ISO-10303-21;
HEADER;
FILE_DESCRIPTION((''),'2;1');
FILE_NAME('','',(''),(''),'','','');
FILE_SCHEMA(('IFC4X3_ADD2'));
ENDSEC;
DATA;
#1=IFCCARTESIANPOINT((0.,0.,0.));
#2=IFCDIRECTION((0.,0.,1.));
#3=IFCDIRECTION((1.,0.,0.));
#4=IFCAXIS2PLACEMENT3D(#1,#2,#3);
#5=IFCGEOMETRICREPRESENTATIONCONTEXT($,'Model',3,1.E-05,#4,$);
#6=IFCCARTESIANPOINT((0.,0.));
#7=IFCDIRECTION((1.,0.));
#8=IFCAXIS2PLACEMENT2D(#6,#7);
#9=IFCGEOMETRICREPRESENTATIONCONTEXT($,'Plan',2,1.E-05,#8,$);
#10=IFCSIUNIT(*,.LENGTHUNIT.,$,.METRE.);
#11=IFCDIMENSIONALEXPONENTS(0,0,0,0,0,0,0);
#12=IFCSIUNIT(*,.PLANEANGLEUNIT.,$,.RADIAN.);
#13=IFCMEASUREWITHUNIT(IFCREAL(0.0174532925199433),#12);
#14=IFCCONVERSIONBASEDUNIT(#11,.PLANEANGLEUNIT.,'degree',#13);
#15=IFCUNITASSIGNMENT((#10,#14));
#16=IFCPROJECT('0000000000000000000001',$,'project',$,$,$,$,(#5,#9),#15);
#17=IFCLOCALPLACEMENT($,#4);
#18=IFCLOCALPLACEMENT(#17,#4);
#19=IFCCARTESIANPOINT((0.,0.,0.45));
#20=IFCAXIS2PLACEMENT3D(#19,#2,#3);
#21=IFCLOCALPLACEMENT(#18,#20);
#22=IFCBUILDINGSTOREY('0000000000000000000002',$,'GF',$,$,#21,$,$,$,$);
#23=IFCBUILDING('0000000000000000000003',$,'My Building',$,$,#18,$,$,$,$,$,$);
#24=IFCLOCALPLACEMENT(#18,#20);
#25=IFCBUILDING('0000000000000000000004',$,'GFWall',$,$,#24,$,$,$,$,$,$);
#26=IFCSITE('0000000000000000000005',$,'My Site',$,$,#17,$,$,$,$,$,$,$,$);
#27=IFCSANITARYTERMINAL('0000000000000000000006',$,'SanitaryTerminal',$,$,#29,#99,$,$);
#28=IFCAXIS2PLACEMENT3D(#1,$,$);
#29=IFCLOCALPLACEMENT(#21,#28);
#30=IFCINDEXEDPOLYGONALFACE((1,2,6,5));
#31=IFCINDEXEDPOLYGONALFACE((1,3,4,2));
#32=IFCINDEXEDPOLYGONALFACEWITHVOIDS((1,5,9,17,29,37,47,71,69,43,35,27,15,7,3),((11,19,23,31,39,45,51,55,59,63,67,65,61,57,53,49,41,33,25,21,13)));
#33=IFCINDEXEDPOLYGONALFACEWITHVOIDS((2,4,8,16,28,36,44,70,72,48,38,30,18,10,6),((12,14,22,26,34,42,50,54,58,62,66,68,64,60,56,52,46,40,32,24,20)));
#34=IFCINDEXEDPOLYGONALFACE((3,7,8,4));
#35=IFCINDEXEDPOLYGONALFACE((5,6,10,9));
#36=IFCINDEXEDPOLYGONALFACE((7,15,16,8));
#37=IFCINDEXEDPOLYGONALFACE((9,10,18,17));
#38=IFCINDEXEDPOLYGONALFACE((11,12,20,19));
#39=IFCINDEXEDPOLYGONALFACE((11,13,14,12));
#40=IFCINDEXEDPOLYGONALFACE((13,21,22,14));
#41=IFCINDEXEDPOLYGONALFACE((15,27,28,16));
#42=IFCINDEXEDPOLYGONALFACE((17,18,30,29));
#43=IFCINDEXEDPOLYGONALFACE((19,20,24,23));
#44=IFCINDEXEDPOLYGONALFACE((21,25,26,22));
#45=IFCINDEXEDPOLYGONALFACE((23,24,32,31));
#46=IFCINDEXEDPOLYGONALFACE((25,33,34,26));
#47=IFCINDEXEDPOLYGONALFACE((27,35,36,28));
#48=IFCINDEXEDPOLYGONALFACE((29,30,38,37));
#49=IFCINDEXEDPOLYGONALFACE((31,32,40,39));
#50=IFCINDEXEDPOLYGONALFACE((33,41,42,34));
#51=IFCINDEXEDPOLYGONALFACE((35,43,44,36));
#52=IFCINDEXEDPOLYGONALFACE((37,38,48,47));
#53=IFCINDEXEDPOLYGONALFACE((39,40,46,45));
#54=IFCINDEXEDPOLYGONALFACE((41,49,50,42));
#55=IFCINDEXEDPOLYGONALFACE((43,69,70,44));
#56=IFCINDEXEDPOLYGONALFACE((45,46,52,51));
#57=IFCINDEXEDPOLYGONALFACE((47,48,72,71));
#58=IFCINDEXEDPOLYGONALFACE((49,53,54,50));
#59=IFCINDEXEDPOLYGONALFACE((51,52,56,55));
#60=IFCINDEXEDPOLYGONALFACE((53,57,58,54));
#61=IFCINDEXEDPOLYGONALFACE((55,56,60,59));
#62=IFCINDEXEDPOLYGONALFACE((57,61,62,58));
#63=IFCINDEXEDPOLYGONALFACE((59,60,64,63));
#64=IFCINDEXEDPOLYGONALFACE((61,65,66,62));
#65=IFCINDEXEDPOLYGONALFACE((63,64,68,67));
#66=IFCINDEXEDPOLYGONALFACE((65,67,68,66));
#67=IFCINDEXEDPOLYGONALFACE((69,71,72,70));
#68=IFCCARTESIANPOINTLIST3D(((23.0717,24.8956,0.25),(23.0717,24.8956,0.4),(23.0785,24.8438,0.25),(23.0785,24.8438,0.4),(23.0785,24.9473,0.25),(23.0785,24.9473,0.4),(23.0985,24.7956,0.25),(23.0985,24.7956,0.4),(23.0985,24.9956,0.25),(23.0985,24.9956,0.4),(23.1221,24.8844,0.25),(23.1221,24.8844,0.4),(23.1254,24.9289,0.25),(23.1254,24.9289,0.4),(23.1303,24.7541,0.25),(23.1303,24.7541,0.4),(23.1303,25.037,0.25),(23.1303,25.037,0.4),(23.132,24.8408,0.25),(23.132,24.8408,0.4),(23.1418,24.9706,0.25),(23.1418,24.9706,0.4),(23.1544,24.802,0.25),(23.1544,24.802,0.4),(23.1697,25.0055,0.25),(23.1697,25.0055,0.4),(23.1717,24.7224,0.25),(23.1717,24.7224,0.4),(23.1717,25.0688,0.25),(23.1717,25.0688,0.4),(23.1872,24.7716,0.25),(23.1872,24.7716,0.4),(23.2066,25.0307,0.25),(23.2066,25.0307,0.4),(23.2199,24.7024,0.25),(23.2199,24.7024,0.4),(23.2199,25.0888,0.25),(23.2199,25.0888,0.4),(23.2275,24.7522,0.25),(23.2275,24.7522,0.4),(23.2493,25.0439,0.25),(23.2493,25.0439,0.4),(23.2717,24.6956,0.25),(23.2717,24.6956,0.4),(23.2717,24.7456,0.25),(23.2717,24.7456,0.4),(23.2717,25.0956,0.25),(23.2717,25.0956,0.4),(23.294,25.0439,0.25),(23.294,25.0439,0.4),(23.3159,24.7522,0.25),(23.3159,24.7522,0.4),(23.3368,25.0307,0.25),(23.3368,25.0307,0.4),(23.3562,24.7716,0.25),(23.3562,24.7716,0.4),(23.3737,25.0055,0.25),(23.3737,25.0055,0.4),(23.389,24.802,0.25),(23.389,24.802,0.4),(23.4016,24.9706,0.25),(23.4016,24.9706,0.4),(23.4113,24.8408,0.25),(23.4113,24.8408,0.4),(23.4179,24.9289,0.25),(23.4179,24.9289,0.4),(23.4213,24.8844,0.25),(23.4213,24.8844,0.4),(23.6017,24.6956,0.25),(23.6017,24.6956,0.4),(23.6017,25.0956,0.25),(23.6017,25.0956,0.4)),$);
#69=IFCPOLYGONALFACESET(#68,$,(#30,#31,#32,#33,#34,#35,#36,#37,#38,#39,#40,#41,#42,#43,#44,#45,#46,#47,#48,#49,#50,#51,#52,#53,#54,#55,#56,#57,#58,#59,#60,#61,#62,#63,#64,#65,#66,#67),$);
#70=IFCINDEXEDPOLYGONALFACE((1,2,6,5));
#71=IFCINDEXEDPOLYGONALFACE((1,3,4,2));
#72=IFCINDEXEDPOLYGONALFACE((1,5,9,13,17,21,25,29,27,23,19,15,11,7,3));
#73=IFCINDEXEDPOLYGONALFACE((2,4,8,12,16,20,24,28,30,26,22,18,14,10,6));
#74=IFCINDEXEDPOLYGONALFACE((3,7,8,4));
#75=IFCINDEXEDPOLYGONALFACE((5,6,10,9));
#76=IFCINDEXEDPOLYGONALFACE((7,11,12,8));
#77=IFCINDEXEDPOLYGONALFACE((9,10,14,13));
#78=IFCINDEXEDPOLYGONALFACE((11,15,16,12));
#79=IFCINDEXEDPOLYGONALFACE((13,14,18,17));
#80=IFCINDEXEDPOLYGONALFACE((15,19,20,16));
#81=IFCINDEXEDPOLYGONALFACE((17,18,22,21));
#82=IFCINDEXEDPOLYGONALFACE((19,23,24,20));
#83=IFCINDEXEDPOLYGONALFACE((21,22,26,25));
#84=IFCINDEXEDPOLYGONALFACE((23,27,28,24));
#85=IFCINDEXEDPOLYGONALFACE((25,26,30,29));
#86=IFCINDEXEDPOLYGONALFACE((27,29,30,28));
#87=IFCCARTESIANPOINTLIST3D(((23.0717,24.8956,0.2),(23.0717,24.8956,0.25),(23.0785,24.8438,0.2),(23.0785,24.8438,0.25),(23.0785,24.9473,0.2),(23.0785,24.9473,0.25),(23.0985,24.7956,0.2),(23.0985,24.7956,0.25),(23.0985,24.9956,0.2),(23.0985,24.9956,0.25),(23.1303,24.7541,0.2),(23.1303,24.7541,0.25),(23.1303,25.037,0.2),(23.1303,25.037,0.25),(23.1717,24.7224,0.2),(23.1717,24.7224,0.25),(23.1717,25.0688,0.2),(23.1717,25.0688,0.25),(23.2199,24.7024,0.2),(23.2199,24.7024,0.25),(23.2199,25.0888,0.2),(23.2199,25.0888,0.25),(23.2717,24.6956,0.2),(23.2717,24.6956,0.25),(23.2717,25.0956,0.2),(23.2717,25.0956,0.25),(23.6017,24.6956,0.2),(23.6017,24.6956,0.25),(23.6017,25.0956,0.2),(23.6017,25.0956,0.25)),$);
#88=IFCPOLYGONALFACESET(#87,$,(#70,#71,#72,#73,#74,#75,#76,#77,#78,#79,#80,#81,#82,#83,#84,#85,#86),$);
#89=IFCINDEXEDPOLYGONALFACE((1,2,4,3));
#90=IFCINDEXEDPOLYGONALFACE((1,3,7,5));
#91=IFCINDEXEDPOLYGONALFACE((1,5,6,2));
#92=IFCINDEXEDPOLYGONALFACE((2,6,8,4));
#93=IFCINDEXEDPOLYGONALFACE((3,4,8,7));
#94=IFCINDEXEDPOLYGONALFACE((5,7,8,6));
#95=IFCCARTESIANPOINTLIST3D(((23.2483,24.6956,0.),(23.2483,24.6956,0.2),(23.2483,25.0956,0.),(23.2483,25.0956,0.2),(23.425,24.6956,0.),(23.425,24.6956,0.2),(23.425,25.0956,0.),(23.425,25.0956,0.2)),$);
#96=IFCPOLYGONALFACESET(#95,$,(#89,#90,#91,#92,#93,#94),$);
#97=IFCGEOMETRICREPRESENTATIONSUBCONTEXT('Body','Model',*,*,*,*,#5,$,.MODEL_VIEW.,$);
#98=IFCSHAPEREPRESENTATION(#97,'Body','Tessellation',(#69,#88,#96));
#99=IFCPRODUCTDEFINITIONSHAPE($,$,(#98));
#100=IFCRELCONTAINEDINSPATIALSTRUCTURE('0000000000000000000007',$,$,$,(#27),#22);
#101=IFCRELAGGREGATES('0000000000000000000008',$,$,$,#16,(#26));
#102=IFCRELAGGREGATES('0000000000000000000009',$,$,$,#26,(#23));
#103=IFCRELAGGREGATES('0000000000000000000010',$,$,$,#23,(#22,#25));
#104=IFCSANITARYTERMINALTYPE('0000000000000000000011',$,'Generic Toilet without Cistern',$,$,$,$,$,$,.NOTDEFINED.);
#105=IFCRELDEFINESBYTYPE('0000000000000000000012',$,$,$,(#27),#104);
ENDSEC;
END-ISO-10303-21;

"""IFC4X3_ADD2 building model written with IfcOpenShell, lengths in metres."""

from ifc_helpers import new_model, entity, si_unit, converted_unit, frame, frame_2d, origin_with_axes, origin_2d_with_axis, place, context, subcontext, project, spatial, line, arc, indexed_curve, circle_curve, outline, extrude, shape, source, transform, mapped, type_object, type_shapes, element, save


model = new_model("IFC4X3_ADD2")

# Units and contexts
model_context = context("Model", 3, precision=1e-05, world=origin_with_axes())
plan_context = context("Plan", 2, precision=1e-05, world=origin_2d_with_axis())
body_context_1 = subcontext(model_context, "Body", "Model", "MODEL_VIEW")
body_context_2 = subcontext(plan_context, "Body", "Plan", "PLAN_VIEW")
ifc_project = project(units=[si_unit("LENGTHUNIT", "METRE"), converted_unit("PLANEANGLEUNIT", "degree", entity("IfcReal", 0.0174532925199433), si_unit("PLANEANGLEUNIT", "RADIAN"), dimensions=[0, 0, 0, 0, 0, 0, 0])], contexts=[model_context, plan_context])

# Site, building, storey
site_placement = place(None, origin_with_axes())
site = spatial("IfcSite", under=ifc_project, at=site_placement, Name="My Site")
building_1_placement = place(site_placement, origin_with_axes())
building_1 = spatial("IfcBuilding", under=site, at=building_1_placement, Name="My Building")
storey_placement = place(building_1_placement, frame((0.0, 0.0, 0.45), z_axis=(0.0, 0.0, 1.0), x_axis=(1.0, 0.0, 0.0)))
storey = spatial("IfcBuildingStorey", under=building_1, at=storey_placement, Name="GF")

# Shared definitions
building_2_placement = place(building_1_placement, frame((0.0, 0.0, 0.45), z_axis=(0.0, 0.0, 1.0), x_axis=(1.0, 0.0, 0.0)))
building_2 = spatial("IfcBuilding", under=building_1, at=building_2_placement, Name="GFWall")

# Sanitary terminal
sanitary_terminal_type_1 = type_object("IfcSanitaryTerminalType", Name="Generic Toilet without Cistern", PredefinedType="NOTDEFINED")
shared_shape_1 = source(origin_with_axes(), body_context_1, "Body", "SweptSolid", [
    extrude(outline(indexed_curve([(-0.2, 0.0), (0.2, 0.0), (0.2, -0.33), (0.1414, -0.4714), (0.0, -0.53), (-0.1414, -0.4714), (-0.2, -0.33)], segments=[line(1, 2), line(2, 3), arc(3, 4, 5), arc(5, 6, 7), line(7, 1)]), holes=[circle_curve(frame_2d((0.0, -0.33)), 0.15)]), frame((0.0, 0.0, 0.25), z_axis=(0.0, 0.0, 1.0), x_axis=(1.0, 0.0, 0.0)), (0.0, 0.0, 1.0), 0.15),
    extrude(outline(indexed_curve([(-0.2, 0.0), (0.2, 0.0), (0.2, -0.33), (0.1414, -0.4714), (0.0, -0.53), (-0.1414, -0.4714), (-0.2, -0.33)], segments=[line(1, 2), line(2, 3), arc(3, 4, 5), arc(5, 6, 7), line(7, 1)])), frame((0.0, 0.0, 0.2), z_axis=(0.0, 0.0, 1.0), x_axis=(1.0, 0.0, 0.0)), (0.0, 0.0, 1.0), 0.05),
    extrude(outline(indexed_curve([(-0.2, -0.1767), (0.2, -0.1767), (0.2, -0.3533), (-0.2, -0.3533)], segments=[line(1, 2, 3, 4, 1)])), origin_with_axes(), (0.0, 0.0, 1.0), 0.2),
])
shared_shape_2 = source(origin_with_axes(), body_context_2, "Body", "Annotation2D", [
    entity("IfcGeometricCurveSet", [entity("IfcIndexedPolyCurve", entity("IfcCartesianPointList2D", [[-0.1068, -0.124], [-0.0957, -0.1129], [-0.0804, -0.1088], [0.0804, -0.1088], [0.0957, -0.1129], [0.1068, -0.124], [0.1109, -0.1393], [0.1109, -0.3476], [0.1025, -0.3926], [0.0784, -0.4308], [0.0424, -0.4563], [0.0, -0.4652], [-0.0424, -0.4563], [-0.0784, -0.4308], [-0.1025, -0.3926], [-0.1109, -0.3476], [-0.1109, -0.1393]]), [entity("IfcLineIndex", [1, 2, 3, 4, 5, 6, 7, 8, 9, 10, 11, 12, 13, 14, 15, 16, 17, 1])]), entity("IfcIndexedPolyCurve", entity("IfcCartesianPointList2D", [[-0.1962, -0.2314], [-0.1848, -0.301], [-0.1764, -0.3339], [-0.1663, -0.3651], [-0.1546, -0.3944], [-0.1414, -0.4213], [-0.1269, -0.4458], [-0.1111, -0.4675], [-0.0943, -0.4862], [-0.0765, -0.5018], [-0.0581, -0.514], [-0.039, -0.5229], [-0.0196, -0.5282], [0.0, -0.53], [0.0196, -0.5282], [0.039, -0.5229], [0.0581, -0.514], [0.0765, -0.5018], [0.0943, -0.4862], [0.1111, -0.4675], [0.1269, -0.4458], [0.1414, -0.4213], [0.1546, -0.3944], [0.1663, -0.3651], [0.1764, -0.3339], [0.1848, -0.301], [0.1962, -0.2314], [0.2, -0.159], [0.1872, 0.0], [-0.1872, 0.0], [-0.2, -0.159]]), [entity("IfcLineIndex", [1, 2, 3, 4, 5, 6, 7, 8, 9, 10, 11, 12, 13, 14, 15, 16, 17, 18, 19, 20, 21, 22, 23, 24, 25, 26, 27, 28, 29, 30, 31, 1])])]),
])
type_shapes(sanitary_terminal_type_1, [shared_shape_1, shared_shape_2])
for number, where, z_axis, x_axis, name in (
    (1, (23.6017, 24.8956, 0.0), (0.0, 0.0, 1.0), (0.0, -1.0, 0.0), "SanitaryTerminal"),
):
    element("IfcSanitaryTerminal", number, at=place(storey_placement, frame(where, z_axis=z_axis, x_axis=x_axis)), inside=storey, type_object=sanitary_terminal_type_1, Name=name, shapes=[
        shape(body_context_1, "Body", "MappedRepresentation", [mapped(shared_shape_1, transform((0.0, 0.0, 0.0), x_axis=(1.0, 0.0, 0.0), y_axis=(0.0, 1.0, 0.0), z_axis=(0.0, 0.0, 1.0), scale=1.0))]),
        shape(body_context_2, "Body", "MappedRepresentation", [mapped(shared_shape_2, transform((0.0, 0.0, 0.0), x_axis=(1.0, 0.0, 0.0), y_axis=(0.0, 1.0, 0.0), z_axis=(0.0, 0.0, 1.0), scale=1.0))]),
    ])

save(model, "model.ifc")
